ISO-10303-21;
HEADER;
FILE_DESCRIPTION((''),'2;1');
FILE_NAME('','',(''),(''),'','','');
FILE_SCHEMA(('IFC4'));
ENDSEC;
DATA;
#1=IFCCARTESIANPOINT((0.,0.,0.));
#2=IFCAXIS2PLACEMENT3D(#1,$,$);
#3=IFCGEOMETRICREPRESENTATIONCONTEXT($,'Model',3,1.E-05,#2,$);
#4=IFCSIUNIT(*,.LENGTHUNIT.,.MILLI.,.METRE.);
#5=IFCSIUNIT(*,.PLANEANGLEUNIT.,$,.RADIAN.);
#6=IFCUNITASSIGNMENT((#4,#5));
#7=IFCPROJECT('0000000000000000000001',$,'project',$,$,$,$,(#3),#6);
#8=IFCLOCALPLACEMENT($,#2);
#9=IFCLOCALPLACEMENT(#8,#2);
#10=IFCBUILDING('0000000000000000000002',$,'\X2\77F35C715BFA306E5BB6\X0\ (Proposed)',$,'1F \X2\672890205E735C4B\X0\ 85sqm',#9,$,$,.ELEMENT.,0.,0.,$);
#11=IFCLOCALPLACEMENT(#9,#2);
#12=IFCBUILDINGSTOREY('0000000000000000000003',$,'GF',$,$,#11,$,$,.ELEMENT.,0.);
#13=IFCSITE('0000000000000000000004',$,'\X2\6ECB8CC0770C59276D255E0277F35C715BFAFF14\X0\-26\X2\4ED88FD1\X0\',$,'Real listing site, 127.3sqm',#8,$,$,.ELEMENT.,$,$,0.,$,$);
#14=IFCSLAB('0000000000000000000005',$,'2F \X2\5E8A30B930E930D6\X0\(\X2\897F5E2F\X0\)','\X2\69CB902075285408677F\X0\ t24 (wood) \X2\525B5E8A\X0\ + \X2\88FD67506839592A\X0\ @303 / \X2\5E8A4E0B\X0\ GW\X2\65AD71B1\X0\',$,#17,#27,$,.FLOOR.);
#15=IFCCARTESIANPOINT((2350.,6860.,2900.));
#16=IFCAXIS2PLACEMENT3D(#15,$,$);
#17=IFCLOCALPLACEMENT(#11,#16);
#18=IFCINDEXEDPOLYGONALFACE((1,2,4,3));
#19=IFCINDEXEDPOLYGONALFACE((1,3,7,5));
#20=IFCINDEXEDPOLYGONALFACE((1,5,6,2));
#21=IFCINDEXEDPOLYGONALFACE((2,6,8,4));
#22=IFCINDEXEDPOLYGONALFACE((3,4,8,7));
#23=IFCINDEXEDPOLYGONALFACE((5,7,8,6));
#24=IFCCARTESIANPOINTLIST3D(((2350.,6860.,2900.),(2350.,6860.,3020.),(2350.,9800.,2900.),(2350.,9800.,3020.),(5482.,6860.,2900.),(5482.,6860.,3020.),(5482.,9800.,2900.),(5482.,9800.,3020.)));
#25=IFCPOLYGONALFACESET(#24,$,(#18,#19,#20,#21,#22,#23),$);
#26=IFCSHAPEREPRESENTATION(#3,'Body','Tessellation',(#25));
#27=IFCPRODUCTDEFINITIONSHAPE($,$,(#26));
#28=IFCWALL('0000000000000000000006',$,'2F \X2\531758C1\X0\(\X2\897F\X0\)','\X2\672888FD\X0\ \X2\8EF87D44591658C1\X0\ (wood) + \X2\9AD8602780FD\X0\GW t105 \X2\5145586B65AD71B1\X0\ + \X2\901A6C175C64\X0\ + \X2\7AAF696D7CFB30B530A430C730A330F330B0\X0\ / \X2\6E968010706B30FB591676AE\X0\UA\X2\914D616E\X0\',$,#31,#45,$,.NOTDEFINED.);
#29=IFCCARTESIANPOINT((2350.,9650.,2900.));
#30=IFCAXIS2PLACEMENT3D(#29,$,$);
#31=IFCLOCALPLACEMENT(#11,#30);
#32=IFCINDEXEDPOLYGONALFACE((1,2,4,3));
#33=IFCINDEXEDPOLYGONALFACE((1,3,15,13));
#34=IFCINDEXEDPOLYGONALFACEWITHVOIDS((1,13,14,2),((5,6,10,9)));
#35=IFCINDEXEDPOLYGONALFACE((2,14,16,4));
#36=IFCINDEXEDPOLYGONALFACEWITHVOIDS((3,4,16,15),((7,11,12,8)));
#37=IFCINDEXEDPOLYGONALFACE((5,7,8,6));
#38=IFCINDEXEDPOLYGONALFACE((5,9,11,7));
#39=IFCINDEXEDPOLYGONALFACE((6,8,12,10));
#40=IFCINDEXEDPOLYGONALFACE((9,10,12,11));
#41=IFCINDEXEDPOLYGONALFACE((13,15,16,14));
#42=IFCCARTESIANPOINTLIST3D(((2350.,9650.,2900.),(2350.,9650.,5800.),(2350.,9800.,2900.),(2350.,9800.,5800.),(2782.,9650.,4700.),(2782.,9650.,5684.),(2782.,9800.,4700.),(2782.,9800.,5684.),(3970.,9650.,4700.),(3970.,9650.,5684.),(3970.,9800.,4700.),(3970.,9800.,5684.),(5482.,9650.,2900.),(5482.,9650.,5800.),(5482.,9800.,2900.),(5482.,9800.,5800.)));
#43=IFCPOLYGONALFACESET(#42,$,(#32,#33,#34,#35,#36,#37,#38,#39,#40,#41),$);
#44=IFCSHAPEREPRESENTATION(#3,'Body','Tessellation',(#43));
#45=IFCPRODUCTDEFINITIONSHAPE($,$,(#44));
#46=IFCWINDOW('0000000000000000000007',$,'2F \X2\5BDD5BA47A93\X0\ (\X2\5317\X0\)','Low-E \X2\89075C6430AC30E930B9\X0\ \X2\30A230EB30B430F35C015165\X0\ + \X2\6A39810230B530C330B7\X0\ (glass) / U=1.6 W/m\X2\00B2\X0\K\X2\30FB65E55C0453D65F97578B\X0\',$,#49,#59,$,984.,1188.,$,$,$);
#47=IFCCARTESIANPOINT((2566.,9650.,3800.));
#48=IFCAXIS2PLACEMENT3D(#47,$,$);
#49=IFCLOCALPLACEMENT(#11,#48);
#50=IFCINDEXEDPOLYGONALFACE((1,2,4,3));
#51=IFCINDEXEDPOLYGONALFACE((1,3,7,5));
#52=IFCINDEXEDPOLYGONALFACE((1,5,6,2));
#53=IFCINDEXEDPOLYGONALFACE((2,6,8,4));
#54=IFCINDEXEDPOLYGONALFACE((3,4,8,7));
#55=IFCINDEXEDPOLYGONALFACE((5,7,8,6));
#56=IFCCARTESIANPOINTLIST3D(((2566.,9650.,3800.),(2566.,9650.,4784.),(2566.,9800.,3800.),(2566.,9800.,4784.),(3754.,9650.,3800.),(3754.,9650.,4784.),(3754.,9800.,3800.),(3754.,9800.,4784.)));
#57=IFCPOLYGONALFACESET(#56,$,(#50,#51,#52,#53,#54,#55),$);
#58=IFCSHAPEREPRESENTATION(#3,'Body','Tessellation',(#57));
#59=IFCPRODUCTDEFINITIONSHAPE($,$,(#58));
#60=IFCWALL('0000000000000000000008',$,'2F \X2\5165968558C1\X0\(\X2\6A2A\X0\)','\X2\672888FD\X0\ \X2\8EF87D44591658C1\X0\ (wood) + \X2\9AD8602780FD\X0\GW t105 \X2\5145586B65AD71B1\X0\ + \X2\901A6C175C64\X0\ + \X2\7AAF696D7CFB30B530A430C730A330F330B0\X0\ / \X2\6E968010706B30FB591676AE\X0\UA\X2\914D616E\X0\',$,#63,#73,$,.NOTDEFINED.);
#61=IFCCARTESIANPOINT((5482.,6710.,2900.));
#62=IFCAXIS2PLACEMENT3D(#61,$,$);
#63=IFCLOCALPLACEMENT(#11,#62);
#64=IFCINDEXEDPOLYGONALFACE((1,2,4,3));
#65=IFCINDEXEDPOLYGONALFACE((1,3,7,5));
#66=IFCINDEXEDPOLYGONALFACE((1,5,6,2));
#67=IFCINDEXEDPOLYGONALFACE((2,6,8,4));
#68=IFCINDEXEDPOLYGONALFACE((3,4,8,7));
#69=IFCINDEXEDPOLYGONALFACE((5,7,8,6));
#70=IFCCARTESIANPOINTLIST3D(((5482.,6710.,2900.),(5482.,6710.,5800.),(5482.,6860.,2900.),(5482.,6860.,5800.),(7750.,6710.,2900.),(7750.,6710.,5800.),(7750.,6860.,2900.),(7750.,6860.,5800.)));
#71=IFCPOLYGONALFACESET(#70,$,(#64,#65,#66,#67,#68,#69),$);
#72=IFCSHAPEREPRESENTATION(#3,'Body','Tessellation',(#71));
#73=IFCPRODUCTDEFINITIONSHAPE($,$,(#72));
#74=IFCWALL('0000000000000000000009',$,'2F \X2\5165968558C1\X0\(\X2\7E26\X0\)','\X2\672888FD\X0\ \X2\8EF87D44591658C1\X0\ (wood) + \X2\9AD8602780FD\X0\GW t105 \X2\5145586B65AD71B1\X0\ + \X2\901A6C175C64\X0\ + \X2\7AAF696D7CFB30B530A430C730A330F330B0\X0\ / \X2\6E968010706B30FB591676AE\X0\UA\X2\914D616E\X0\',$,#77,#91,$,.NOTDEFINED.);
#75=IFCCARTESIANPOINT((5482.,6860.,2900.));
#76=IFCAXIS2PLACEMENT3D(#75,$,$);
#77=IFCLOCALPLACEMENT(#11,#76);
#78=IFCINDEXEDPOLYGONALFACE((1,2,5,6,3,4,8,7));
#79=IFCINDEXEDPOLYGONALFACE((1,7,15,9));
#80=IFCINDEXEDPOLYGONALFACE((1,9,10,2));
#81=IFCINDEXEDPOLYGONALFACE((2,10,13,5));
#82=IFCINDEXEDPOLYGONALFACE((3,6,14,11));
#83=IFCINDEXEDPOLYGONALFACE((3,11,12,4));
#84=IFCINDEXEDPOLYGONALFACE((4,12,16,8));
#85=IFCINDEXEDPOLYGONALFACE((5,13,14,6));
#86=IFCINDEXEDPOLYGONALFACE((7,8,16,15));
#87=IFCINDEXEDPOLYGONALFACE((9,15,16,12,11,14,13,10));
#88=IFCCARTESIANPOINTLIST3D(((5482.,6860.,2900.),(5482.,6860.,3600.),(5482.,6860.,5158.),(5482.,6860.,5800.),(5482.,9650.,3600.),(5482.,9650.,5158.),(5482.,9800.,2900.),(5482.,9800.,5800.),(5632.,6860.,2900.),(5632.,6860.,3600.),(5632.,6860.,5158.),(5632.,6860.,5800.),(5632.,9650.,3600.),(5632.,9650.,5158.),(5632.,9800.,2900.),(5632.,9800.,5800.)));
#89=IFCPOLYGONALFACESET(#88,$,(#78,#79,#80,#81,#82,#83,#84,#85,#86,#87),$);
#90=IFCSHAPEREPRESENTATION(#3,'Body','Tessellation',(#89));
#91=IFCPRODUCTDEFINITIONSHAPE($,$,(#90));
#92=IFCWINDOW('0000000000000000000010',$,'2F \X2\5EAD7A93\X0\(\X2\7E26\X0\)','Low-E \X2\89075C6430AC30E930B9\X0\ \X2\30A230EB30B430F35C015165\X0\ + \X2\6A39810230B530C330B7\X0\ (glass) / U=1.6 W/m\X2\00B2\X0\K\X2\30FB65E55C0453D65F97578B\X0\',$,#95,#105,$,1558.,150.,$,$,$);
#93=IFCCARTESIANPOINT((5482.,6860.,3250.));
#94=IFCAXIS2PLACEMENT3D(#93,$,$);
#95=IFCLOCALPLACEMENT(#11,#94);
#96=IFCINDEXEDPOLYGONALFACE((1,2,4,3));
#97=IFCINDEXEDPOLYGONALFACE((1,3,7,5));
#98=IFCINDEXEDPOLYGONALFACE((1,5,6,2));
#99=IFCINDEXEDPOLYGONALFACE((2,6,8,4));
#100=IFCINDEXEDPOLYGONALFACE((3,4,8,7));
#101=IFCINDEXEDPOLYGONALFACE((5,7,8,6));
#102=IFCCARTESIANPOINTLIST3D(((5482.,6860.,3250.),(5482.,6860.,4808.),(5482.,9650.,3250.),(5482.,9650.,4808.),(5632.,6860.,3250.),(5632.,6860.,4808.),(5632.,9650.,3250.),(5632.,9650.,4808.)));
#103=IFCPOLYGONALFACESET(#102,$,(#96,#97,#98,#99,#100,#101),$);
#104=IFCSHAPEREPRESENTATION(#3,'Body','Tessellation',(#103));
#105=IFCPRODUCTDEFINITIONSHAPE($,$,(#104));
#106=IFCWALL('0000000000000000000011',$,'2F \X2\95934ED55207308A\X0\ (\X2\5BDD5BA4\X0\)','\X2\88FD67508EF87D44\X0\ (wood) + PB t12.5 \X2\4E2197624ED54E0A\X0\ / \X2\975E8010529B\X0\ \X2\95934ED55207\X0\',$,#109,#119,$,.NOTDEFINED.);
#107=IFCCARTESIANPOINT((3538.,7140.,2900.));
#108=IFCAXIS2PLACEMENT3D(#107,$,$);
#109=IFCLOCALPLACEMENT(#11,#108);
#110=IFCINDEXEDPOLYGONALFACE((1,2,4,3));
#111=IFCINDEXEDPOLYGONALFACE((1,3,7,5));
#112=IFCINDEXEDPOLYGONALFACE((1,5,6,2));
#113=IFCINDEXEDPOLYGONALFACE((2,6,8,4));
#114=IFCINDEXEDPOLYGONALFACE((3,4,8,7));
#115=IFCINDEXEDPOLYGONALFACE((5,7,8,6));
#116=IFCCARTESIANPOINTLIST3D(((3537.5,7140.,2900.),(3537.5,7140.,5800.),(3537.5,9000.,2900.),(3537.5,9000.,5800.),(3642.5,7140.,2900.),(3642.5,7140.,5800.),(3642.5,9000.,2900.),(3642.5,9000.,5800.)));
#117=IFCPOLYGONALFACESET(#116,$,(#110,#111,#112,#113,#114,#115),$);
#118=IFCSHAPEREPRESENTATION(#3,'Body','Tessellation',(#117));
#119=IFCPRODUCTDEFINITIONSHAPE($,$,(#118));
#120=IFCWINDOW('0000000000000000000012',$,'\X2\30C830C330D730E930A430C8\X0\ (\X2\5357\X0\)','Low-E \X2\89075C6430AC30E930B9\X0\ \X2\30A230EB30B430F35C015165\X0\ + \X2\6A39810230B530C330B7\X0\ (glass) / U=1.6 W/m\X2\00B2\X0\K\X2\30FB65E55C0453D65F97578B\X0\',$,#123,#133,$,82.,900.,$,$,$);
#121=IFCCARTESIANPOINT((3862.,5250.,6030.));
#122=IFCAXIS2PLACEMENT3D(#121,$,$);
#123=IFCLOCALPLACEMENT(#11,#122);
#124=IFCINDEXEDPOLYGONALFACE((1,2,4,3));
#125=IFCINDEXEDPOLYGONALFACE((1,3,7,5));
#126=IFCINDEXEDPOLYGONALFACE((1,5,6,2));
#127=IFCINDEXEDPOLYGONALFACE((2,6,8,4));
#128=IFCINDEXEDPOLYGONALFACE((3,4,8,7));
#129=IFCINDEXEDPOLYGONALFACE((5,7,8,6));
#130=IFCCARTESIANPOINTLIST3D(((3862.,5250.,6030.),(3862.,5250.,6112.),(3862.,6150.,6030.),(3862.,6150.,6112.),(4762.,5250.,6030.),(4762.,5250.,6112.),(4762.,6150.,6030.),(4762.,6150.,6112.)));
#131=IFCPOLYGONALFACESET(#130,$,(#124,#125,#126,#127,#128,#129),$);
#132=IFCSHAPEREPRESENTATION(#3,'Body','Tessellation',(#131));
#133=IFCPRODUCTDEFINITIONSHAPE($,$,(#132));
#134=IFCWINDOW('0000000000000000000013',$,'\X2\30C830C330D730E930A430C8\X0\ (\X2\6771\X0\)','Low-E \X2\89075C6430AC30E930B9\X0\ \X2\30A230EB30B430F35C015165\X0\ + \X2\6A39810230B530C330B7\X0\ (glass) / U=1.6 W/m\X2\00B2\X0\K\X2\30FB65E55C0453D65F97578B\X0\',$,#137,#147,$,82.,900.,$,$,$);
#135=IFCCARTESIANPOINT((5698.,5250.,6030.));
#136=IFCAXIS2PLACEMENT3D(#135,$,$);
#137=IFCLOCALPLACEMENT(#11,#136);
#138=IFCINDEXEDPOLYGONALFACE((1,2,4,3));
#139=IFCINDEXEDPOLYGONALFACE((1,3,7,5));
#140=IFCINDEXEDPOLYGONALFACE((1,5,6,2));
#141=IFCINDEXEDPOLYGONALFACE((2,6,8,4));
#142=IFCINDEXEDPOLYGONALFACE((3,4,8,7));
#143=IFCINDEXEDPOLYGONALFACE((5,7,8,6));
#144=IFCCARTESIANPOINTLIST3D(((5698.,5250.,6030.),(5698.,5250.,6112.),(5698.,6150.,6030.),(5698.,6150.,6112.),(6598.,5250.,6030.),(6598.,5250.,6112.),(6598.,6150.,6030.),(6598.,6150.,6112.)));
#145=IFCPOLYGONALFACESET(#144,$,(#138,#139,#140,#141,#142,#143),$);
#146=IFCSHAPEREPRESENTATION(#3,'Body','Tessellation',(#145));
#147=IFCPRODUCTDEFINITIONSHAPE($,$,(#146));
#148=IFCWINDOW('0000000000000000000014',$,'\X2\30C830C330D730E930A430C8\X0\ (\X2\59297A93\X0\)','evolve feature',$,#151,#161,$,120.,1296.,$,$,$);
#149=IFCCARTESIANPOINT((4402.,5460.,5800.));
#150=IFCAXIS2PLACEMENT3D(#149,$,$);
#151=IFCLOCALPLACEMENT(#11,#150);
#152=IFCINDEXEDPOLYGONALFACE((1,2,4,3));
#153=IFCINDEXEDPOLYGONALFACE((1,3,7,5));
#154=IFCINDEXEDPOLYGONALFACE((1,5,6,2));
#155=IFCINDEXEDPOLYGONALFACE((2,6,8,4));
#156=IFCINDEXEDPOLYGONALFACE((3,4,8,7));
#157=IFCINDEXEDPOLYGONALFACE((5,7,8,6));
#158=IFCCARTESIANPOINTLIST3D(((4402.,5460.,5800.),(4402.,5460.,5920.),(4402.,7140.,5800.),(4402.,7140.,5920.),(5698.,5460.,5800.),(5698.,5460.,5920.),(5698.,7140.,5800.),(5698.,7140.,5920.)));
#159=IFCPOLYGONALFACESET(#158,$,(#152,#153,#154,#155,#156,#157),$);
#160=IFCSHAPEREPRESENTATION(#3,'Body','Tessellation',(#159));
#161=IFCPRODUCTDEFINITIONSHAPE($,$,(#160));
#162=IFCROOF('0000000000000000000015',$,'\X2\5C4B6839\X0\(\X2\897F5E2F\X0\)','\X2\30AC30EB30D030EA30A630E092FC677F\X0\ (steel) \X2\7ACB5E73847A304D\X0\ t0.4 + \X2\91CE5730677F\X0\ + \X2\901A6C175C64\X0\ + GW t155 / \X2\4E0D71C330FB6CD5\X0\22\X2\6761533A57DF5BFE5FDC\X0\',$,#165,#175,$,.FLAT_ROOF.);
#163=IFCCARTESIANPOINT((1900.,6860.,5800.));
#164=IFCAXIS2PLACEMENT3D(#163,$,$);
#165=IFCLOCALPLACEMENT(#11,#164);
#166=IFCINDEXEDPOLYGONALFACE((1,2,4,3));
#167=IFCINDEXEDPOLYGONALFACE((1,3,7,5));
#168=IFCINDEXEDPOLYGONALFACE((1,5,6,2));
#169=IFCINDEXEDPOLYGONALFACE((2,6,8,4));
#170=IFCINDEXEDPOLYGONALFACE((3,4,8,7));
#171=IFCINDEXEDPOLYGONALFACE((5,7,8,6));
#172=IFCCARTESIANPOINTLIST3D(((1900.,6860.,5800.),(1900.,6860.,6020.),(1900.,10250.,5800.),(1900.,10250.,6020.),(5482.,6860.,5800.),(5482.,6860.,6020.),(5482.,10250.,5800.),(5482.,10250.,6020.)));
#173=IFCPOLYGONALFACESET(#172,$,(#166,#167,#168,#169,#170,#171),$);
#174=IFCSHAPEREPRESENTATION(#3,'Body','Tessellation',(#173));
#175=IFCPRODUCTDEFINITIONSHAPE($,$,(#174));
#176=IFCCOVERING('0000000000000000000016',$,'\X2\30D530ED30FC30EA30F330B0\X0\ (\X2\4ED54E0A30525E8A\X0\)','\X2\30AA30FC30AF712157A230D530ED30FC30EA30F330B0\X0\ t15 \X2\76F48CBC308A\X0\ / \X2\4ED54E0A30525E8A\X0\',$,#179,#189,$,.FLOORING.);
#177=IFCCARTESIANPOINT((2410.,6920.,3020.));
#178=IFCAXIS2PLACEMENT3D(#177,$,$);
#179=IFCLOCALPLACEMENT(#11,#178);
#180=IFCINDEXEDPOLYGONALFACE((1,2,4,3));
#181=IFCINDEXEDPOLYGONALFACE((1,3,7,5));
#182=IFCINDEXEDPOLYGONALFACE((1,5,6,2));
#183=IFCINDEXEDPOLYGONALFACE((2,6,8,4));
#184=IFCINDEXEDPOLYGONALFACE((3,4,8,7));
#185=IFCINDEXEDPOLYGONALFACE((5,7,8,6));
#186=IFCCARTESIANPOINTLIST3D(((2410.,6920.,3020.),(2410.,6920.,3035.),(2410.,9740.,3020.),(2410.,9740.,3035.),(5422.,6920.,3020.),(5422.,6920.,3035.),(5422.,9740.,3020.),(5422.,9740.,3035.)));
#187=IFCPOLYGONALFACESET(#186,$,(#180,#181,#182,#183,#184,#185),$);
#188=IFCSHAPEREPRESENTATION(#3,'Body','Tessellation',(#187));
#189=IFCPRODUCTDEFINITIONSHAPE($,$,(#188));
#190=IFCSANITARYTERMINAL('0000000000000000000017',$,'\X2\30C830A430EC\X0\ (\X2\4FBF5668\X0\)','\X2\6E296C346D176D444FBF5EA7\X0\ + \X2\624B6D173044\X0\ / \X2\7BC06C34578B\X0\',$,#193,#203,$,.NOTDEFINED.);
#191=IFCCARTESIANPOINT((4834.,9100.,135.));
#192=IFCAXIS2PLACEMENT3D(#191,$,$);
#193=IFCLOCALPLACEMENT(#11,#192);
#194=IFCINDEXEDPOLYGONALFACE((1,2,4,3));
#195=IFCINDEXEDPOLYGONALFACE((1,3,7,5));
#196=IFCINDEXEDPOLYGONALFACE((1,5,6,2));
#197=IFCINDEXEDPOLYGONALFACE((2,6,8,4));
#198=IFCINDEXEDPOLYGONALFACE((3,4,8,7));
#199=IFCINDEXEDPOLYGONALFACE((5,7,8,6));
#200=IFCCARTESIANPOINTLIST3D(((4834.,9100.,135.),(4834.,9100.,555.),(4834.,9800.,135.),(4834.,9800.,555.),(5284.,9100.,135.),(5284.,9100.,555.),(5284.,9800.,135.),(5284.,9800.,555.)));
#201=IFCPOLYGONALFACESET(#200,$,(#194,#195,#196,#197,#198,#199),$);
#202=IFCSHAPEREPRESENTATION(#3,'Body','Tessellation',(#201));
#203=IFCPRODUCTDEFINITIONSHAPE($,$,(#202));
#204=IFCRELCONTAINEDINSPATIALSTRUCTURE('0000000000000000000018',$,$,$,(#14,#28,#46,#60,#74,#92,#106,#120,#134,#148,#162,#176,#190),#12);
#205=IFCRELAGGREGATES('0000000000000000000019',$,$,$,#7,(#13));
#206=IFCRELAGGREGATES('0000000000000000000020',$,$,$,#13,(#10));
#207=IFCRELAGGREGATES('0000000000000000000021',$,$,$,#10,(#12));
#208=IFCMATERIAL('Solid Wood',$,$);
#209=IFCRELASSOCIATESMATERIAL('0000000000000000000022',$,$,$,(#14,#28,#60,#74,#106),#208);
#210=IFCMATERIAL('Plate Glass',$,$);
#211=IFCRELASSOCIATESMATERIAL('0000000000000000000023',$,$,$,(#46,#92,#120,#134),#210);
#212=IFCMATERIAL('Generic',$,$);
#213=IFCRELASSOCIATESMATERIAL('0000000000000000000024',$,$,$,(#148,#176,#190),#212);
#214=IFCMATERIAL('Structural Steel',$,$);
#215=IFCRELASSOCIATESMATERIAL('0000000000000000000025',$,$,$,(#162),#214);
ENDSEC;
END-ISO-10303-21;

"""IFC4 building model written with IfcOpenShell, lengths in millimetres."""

from ifc_helpers import new_model, si_unit, frame, frame_2d, origin, place, context, project, spatial, rectangle, extrude, material, element, fill, save


model = new_model("IFC4")

# Units and contexts
model_context = context("Model", 3, precision=1e-05, world=origin())
ifc_project = project(units=[si_unit("LENGTHUNIT", "METRE", prefix="MILLI"), si_unit("PLANEANGLEUNIT", "RADIAN")], contexts=[model_context])

# Site, building, storey
site_placement = place(None, origin())
site = spatial("IfcSite", under=ifc_project, at=site_placement, Name="滋賀県大津市石山寺４-26付近", ObjectType="Real listing site, 127.3sqm", CompositionType="ELEMENT", RefElevation=0.0)
building_placement = place(site_placement, origin())
building = spatial("IfcBuilding", under=site, at=building_placement, Name="石山寺の家 (Proposed)", ObjectType="1F 木造平屋 85sqm", CompositionType="ELEMENT", ElevationOfRefHeight=0.0, ElevationOfTerrain=0.0)
storey_placement = place(building_placement, origin())
storey = spatial("IfcBuildingStorey", under=building, at=storey_placement, Name="GF", CompositionType="ELEMENT", Elevation=0.0)

# Slab
ifc_material_1 = material(Name="Solid Wood")
slab_placement = place(storey_placement, frame((2350.0, 6860.0, 2900.0)))
element("IfcSlab", 1, at=slab_placement, inside=storey, material=ifc_material_1, Name="2F 床スラブ(西帯)", Description="構造用合板 t24 (wood) 剛床 + 製材根太 @303 / 床下 GW断熱", PredefinedType="FLOOR", context=model_context, shape_type="SweptSolid", body=[
    extrude(rectangle(XDim=3132.0, YDim=2940.0, at=frame_2d((1566.0, 1470.0))), frame((2350.0, 6860.0, 2900.0)), (0.0, 0.0, 1.0), 120.0),
])

# Wall, opening, window
wall_1_placement = place(storey_placement, frame((2350.0, 9650.0, 2900.0)))
wall_1 = element("IfcWall", 2, at=wall_1_placement, inside=storey, material=ifc_material_1, Name="2F 北壁(西)", Description="木製 軸組外壁 (wood) + 高性能GW t105 充填断熱 + 通気層 + 窯業系サイディング / 準耐火・外皮UA配慮", PredefinedType="NOTDEFINED", context=model_context, shape_type="SweptSolid", body=[
    extrude(rectangle(XDim=3132.0, YDim=150.0, at=frame_2d((1566.0, 75.0))), frame((2350.0, 9650.0, 2900.0)), (0.0, 0.0, 1.0), 2900.0),
])
opening_1_placement = place(storey_placement, frame((2566.0, 9650.0, 3800.0)))
opening_1 = element("IfcOpeningElement", 3, at=opening_1_placement, cuts=wall_1, PredefinedType="NOTDEFINED", context=model_context, shape_type="SweptSolid", body=[
    extrude(rectangle(XDim=1188.0, YDim=150.0, at=frame_2d((594.0, 75.0))), frame((2566.0, 9650.0, 3800.0)), (0.0, 0.0, 1.0), 984.0),
])
ifc_material_2 = material(Name="Plate Glass")
window_1_placement = place(storey_placement, frame((2566.0, 9650.0, 3800.0)))
window_1 = element("IfcWindow", 4, at=window_1_placement, inside=storey, material=ifc_material_2, Name="2F 寝室窓 (北)", Description="Low-E 複層ガラス アルゴン封入 + 樹脂サッシ (glass) / U=1.6 W/m²K・日射取得型", OverallHeight=984.0, OverallWidth=1188.0, context=model_context, shape_type="SweptSolid", body=[
    extrude(rectangle(XDim=1188.0, YDim=150.0, at=frame_2d((594.0, 75.0))), frame((2566.0, 9650.0, 3800.0)), (0.0, 0.0, 1.0), 984.0),
])
fill(opening_1, window_1)

# Wall
wall_2_placement = place(storey_placement, frame((5482.0, 6710.0, 2900.0)))
element("IfcWall", 5, at=wall_2_placement, inside=storey, material=ifc_material_1, Name="2F 入隅壁(横)", Description="木製 軸組外壁 (wood) + 高性能GW t105 充填断熱 + 通気層 + 窯業系サイディング / 準耐火・外皮UA配慮", PredefinedType="NOTDEFINED", context=model_context, shape_type="SweptSolid", body=[
    extrude(rectangle(XDim=2268.0, YDim=150.0, at=frame_2d((1134.0, 75.0))), frame((5482.0, 6710.0, 2900.0)), (0.0, 0.0, 1.0), 2900.0),
])

# Wall, opening, window
wall_3_placement = place(storey_placement, frame((5482.0, 6860.0, 2900.0)))
wall_3 = element("IfcWall", 6, at=wall_3_placement, inside=storey, material=ifc_material_1, Name="2F 入隅壁(縦)", Description="木製 軸組外壁 (wood) + 高性能GW t105 充填断熱 + 通気層 + 窯業系サイディング / 準耐火・外皮UA配慮", PredefinedType="NOTDEFINED", context=model_context, shape_type="SweptSolid", body=[
    extrude(rectangle(XDim=150.0, YDim=2940.0, at=frame_2d((75.0, 1470.0))), frame((5482.0, 6860.0, 2900.0)), (0.0, 0.0, 1.0), 2900.0),
])
opening_2_placement = place(storey_placement, frame((5482.0, 6860.0, 3250.0)))
opening_2 = element("IfcOpeningElement", 7, at=opening_2_placement, cuts=wall_3, PredefinedType="NOTDEFINED", context=model_context, shape_type="SweptSolid", body=[
    extrude(rectangle(XDim=150.0, YDim=2790.0, at=frame_2d((75.0, 1395.0))), frame((5482.0, 6860.0, 3250.0)), (0.0, 0.0, 1.0), 1558.0),
])
window_2_placement = place(storey_placement, frame((5482.0, 6860.0, 3250.0)))
window_2 = element("IfcWindow", 8, at=window_2_placement, inside=storey, material=ifc_material_2, Name="2F 庭窓(縦)", Description="Low-E 複層ガラス アルゴン封入 + 樹脂サッシ (glass) / U=1.6 W/m²K・日射取得型", OverallHeight=1558.0, OverallWidth=150.0, context=model_context, shape_type="SweptSolid", body=[
    extrude(rectangle(XDim=150.0, YDim=2790.0, at=frame_2d((75.0, 1395.0))), frame((5482.0, 6860.0, 3250.0)), (0.0, 0.0, 1.0), 1558.0),
])
fill(opening_2, window_2)

# Wall
wall_4_placement = place(storey_placement, frame((3538.0, 7140.0, 2900.0)))
element("IfcWall", 9, at=wall_4_placement, inside=storey, material=ifc_material_1, Name="2F 間仕切り (寝室)", Description="製材軸組 (wood) + PB t12.5 両面仕上 / 非耐力 間仕切", PredefinedType="NOTDEFINED", context=model_context, shape_type="SweptSolid", body=[
    extrude(rectangle(XDim=105.0, YDim=1860.0, at=frame_2d((52.0, 930.0))), frame((3538.0, 7140.0, 2900.0)), (0.0, 0.0, 1.0), 2900.0),
])

# Windows
window_3_placement = place(storey_placement, frame((3862.0, 5250.0, 6030.0)))
element("IfcWindow", 10, at=window_3_placement, inside=storey, material=ifc_material_2, Name="トップライト (南)", Description="Low-E 複層ガラス アルゴン封入 + 樹脂サッシ (glass) / U=1.6 W/m²K・日射取得型", OverallHeight=82.0, OverallWidth=900.0, context=model_context, shape_type="SweptSolid", body=[
    extrude(rectangle(XDim=900.0, YDim=900.0, at=frame_2d((450.0, 450.0))), frame((3862.0, 5250.0, 6030.0)), (0.0, 0.0, 1.0), 82.0),
])
window_4_placement = place(storey_placement, frame((5698.0, 5250.0, 6030.0)))
element("IfcWindow", 11, at=window_4_placement, inside=storey, material=ifc_material_2, Name="トップライト (東)", Description="Low-E 複層ガラス アルゴン封入 + 樹脂サッシ (glass) / U=1.6 W/m²K・日射取得型", OverallHeight=82.0, OverallWidth=900.0, context=model_context, shape_type="SweptSolid", body=[
    extrude(rectangle(XDim=900.0, YDim=900.0, at=frame_2d((450.0, 450.0))), frame((5698.0, 5250.0, 6030.0)), (0.0, 0.0, 1.0), 82.0),
])
ifc_material_3 = material(Name="Generic")
window_5_placement = place(storey_placement, frame((4402.0, 5460.0, 5800.0)))
element("IfcWindow", 12, at=window_5_placement, inside=storey, material=ifc_material_3, Name="トップライト (天窓)", Description="evolve feature", OverallHeight=120.0, OverallWidth=1296.0, context=model_context, shape_type="SweptSolid", body=[
    extrude(rectangle(XDim=1296.0, YDim=1680.0, at=frame_2d((648.0, 840.0))), frame((4402.0, 5460.0, 5800.0)), (0.0, 0.0, 1.0), 120.0),
])

# Roof
ifc_material_4 = material(Name="Structural Steel")
for number, where, name in (
    (13, (1900.0, 6860.0, 5800.0), "屋根(西帯)"),
):
    element("IfcRoof", number, at=place(storey_placement, frame(where)), inside=storey, material=ifc_material_4, Name=name, Description="ガルバリウム鋼板 (steel) 立平葺き t0.4 + 野地板 + 通気層 + GW t155 / 不燃・法22条区域対応", PredefinedType="FLAT_ROOF", context=model_context, shape_type="SweptSolid", body=[
        extrude(rectangle(XDim=3582.0, YDim=3390.0, at=frame_2d((1791.0, 1695.0))), frame((1900.0, 6860.0, 5800.0)), (0.0, 0.0, 1.0), 220.0),
    ])

# Covering
covering_placement = place(storey_placement, frame((2410.0, 6920.0, 3020.0)))
element("IfcCovering", 14, at=covering_placement, inside=storey, material=ifc_material_3, Name="フローリング (仕上げ床)", Description="オーク無垢フローリング t15 直貼り / 仕上げ床", PredefinedType="FLOORING", context=model_context, shape_type="SweptSolid", body=[
    extrude(rectangle(XDim=3012.0, YDim=2820.0, at=frame_2d((1506.0, 1410.0))), frame((2410.0, 6920.0, 3020.0)), (0.0, 0.0, 1.0), 15.0),
])

# Sanitary terminal
sanitary_terminal_placement = place(storey_placement, frame((4834.0, 9100.0, 135.0)))
element("IfcSanitaryTerminal", 15, at=sanitary_terminal_placement, inside=storey, material=ifc_material_3, Name="トイレ (便器)", Description="温水洗浄便座 + 手洗い / 節水型", PredefinedType="NOTDEFINED", context=model_context, shape_type="SweptSolid", body=[
    extrude(rectangle(XDim=450.0, YDim=700.0, at=frame_2d((225.0, 350.0))), frame((4834.0, 9100.0, 135.0)), (0.0, 0.0, 1.0), 420.0),
])

save(model, "model.ifc")
